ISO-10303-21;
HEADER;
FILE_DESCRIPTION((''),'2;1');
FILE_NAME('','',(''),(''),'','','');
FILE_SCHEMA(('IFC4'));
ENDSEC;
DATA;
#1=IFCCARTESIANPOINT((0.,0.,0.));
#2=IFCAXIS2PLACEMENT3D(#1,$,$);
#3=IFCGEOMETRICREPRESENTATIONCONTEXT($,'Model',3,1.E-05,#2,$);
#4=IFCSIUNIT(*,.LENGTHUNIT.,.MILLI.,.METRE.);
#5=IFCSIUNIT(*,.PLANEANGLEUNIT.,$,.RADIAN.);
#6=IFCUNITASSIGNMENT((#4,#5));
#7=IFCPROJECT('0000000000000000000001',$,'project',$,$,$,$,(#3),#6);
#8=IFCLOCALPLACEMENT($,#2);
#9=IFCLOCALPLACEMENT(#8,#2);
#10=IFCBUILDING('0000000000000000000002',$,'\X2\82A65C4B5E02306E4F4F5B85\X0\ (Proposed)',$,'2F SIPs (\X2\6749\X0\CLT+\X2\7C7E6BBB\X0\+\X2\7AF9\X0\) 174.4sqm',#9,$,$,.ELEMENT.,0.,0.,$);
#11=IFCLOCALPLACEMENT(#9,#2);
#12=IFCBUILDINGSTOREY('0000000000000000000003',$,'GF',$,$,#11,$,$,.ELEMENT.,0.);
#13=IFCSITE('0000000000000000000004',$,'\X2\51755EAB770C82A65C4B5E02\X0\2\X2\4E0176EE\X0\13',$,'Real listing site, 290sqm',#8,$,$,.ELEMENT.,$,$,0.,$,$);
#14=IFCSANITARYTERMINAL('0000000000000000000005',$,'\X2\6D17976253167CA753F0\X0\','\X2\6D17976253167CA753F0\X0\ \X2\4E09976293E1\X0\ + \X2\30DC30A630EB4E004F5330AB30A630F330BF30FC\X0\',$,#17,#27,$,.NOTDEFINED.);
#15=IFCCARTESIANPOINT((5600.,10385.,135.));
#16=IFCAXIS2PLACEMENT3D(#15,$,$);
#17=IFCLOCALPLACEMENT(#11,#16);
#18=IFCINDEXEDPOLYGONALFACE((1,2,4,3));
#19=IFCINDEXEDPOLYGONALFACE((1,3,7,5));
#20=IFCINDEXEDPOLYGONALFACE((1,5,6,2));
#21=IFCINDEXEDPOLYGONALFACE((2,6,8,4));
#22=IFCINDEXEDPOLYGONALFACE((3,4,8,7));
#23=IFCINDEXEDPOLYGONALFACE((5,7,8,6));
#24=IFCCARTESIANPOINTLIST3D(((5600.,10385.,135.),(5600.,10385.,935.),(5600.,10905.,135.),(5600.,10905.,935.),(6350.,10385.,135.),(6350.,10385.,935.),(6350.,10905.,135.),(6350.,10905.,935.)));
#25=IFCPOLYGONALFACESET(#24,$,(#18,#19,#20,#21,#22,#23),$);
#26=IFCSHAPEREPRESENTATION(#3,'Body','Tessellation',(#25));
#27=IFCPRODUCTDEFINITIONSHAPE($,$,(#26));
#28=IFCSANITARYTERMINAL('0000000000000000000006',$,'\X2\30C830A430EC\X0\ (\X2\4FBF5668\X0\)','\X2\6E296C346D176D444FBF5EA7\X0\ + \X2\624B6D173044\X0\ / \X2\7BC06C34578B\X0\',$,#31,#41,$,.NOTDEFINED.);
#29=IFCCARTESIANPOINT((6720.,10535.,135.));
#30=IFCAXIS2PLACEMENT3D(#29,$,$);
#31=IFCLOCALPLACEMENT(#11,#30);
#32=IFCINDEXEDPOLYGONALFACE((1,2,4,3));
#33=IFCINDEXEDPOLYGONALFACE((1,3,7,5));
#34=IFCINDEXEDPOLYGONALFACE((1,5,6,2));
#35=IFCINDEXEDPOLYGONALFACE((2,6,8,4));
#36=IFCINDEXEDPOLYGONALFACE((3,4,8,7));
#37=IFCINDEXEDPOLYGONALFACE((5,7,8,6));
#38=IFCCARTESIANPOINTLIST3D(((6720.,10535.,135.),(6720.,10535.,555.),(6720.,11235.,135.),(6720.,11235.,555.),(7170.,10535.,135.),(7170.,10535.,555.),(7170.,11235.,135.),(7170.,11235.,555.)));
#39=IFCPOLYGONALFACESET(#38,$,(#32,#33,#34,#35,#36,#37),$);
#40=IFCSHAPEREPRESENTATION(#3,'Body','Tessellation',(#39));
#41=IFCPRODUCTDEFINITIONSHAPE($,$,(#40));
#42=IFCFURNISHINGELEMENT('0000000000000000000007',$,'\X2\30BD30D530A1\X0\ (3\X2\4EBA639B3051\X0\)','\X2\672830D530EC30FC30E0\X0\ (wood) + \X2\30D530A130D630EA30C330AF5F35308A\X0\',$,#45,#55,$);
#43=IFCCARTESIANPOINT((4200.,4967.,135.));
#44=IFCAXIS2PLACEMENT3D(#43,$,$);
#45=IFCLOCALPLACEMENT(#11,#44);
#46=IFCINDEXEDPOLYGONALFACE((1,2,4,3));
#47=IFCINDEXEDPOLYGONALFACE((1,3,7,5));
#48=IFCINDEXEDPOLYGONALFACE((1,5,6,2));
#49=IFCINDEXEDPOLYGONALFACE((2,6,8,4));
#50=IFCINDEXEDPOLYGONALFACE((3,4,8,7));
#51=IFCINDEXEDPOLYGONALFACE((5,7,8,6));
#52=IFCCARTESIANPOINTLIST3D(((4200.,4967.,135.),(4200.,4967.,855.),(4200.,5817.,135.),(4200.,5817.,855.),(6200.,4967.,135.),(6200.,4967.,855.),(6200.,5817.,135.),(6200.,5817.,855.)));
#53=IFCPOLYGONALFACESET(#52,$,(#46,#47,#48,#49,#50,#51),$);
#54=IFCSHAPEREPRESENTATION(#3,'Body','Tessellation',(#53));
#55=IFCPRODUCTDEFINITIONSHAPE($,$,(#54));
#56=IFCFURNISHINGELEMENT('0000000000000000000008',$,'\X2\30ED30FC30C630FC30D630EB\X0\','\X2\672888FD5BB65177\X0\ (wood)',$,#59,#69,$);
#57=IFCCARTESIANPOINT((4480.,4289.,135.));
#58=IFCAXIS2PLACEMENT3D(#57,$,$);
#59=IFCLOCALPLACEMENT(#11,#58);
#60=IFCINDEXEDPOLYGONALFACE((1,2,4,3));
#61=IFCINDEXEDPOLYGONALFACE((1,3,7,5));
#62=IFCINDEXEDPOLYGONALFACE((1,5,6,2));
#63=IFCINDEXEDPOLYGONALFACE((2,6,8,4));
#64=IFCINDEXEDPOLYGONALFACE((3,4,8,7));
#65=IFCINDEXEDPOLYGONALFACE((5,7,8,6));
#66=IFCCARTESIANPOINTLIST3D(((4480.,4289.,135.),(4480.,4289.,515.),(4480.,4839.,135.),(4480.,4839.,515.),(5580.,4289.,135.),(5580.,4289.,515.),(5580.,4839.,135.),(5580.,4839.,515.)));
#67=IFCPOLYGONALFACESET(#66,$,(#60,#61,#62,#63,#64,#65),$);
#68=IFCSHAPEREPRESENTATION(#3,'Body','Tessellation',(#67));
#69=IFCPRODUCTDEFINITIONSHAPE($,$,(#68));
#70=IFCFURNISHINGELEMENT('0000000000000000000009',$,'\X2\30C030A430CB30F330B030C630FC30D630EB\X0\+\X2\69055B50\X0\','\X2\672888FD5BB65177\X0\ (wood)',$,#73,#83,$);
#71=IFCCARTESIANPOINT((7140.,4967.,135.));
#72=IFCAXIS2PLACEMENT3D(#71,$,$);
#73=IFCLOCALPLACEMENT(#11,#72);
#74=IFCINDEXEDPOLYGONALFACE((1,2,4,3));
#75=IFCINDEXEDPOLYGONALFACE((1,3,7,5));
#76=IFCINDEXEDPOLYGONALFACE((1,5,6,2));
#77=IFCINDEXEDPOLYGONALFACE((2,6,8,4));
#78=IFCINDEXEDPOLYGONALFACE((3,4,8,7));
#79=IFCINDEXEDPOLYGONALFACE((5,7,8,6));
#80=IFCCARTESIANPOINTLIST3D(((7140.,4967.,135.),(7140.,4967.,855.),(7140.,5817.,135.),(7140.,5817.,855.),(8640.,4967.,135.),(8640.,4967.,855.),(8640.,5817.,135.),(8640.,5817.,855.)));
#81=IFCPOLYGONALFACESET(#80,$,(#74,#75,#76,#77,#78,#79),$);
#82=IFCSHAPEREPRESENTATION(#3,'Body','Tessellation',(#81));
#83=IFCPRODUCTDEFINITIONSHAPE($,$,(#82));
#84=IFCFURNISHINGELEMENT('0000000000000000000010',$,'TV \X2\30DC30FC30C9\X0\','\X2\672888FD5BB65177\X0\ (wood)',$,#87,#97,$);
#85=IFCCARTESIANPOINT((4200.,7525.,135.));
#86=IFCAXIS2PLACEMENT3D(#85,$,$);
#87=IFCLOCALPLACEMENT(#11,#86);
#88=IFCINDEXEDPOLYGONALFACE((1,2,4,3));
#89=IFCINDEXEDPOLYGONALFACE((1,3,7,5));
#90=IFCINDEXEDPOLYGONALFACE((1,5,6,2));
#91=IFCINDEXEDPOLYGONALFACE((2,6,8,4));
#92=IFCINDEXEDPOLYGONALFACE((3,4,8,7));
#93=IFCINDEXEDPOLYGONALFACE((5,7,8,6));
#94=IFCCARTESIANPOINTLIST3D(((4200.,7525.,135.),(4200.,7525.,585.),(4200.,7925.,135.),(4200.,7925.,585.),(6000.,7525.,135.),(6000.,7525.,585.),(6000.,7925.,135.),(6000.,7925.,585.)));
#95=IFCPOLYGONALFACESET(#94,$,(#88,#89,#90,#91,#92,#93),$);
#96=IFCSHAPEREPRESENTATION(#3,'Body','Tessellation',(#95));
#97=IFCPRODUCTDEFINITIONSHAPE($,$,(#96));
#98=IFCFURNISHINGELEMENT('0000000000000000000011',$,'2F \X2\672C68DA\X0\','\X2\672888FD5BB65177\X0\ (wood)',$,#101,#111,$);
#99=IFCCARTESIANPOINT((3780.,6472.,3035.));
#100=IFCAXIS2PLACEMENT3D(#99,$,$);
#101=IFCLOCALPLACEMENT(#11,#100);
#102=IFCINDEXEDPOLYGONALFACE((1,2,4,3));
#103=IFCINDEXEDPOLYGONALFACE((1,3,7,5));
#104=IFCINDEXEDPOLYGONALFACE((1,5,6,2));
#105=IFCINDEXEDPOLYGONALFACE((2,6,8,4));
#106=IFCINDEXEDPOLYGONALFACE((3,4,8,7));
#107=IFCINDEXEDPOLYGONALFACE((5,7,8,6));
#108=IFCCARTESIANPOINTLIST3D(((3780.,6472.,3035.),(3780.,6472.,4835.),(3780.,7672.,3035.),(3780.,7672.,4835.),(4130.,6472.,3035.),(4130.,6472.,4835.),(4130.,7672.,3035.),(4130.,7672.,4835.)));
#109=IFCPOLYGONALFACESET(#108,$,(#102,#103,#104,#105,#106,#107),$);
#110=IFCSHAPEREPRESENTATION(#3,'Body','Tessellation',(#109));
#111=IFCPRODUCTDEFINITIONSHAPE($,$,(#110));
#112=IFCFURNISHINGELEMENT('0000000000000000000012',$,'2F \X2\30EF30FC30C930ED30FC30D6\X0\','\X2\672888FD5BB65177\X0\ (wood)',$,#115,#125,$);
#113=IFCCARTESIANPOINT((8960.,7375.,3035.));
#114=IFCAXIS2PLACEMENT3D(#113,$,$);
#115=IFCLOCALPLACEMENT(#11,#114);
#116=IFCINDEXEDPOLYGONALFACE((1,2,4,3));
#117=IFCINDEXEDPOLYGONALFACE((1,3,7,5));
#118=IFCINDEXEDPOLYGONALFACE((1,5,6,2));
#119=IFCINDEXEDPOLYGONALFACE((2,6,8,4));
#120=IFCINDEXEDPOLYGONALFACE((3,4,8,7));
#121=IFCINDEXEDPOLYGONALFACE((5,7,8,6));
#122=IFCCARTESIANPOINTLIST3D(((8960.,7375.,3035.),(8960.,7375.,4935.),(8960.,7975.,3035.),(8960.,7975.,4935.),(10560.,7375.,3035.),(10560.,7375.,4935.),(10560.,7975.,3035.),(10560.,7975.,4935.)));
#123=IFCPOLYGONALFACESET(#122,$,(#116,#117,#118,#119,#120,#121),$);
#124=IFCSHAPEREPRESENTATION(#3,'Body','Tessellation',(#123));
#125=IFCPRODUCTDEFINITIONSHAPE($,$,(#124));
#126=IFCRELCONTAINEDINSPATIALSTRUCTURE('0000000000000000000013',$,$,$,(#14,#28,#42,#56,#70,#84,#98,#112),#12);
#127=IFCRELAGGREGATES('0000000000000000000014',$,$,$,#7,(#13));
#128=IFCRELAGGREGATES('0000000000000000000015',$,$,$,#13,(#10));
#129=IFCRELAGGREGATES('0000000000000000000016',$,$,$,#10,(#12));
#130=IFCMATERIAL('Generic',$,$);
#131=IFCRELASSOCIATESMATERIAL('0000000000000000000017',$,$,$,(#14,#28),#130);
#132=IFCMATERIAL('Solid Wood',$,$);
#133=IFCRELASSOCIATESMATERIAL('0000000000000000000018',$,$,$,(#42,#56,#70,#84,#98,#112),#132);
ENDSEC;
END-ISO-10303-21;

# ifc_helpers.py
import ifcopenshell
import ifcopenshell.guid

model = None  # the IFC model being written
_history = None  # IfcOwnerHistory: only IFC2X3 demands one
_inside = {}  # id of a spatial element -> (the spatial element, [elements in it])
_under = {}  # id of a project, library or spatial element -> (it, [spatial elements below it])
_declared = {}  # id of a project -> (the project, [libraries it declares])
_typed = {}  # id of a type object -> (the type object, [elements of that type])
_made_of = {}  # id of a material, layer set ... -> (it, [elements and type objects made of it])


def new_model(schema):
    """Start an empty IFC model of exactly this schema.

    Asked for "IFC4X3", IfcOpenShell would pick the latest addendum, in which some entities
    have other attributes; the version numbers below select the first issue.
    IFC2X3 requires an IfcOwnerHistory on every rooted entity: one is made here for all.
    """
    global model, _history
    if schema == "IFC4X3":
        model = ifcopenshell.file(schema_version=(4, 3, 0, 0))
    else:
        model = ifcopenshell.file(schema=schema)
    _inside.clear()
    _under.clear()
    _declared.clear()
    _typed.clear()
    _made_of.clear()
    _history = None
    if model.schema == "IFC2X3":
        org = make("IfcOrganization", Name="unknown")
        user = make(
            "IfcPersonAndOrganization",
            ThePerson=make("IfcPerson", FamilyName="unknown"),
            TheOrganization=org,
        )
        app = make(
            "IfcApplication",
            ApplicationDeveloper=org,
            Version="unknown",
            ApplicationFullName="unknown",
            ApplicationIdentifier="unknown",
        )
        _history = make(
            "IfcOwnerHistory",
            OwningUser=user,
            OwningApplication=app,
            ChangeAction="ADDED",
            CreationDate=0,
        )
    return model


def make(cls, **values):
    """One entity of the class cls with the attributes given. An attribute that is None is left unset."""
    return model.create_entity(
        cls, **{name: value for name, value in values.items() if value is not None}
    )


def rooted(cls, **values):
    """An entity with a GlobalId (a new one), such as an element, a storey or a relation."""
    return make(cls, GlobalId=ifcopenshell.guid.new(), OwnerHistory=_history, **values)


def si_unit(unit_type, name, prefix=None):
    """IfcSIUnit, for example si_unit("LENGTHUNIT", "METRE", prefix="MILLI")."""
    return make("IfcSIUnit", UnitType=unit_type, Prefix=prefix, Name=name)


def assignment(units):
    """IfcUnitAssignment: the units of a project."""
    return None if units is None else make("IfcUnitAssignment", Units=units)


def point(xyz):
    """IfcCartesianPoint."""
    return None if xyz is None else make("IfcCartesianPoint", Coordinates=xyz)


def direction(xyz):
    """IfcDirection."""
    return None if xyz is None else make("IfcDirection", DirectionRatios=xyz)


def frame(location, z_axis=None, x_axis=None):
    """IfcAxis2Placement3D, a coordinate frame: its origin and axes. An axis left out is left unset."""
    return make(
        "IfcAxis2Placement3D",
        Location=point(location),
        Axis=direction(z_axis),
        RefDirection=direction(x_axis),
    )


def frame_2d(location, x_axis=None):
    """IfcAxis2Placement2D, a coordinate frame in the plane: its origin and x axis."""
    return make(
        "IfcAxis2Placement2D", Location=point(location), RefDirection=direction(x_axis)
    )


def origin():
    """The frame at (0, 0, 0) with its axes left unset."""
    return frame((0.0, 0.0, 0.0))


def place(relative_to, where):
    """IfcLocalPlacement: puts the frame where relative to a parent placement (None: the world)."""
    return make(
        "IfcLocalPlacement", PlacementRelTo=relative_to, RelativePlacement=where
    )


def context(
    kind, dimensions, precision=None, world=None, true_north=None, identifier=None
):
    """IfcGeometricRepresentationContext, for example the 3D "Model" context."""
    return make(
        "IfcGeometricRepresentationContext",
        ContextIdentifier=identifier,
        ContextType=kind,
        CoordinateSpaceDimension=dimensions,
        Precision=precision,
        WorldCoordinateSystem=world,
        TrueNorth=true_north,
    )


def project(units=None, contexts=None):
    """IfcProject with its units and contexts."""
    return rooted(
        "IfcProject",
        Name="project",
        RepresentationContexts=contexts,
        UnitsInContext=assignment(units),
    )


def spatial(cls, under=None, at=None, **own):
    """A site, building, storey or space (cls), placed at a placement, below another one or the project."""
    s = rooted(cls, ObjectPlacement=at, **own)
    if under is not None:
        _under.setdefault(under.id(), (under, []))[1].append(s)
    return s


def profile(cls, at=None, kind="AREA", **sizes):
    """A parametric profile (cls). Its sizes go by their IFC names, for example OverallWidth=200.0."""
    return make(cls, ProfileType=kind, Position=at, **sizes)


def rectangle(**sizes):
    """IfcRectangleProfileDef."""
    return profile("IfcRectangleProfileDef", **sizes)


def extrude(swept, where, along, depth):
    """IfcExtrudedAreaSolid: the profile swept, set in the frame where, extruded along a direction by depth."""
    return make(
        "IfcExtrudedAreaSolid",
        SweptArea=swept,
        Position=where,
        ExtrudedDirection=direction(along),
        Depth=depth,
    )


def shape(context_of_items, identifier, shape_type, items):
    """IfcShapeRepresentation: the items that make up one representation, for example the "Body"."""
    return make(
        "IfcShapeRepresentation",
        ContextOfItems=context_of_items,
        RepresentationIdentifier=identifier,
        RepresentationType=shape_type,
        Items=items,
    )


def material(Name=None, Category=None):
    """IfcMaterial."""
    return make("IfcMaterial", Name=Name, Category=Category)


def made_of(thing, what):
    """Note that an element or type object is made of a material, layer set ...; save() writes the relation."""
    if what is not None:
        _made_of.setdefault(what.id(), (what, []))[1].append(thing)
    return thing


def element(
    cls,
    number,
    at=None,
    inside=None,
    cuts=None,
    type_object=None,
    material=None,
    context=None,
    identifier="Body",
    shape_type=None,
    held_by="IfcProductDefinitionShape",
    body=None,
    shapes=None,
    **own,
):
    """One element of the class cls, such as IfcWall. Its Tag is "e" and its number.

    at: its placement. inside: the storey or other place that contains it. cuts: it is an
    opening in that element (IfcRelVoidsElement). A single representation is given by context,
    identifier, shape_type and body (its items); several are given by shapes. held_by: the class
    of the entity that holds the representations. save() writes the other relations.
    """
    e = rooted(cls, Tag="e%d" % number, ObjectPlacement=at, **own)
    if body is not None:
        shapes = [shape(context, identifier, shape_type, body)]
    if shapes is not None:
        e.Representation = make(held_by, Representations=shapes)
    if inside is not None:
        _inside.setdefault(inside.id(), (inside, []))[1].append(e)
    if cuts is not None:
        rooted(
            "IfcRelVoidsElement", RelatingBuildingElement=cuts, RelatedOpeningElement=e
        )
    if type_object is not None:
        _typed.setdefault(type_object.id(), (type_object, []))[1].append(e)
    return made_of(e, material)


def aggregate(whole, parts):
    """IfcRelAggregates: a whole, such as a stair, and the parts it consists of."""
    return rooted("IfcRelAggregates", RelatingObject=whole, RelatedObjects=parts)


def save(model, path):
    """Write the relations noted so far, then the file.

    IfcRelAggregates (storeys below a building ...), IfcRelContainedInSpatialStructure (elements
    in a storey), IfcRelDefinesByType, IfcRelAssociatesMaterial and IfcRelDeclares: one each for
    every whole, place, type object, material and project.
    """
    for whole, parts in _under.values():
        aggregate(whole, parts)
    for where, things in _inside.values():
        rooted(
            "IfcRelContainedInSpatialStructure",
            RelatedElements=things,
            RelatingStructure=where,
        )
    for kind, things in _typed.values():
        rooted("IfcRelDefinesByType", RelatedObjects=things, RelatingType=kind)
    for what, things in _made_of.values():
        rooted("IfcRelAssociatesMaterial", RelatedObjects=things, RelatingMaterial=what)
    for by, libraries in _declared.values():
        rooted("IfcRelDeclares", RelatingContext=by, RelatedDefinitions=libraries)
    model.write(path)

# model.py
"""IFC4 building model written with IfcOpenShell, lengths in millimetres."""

from ifc_helpers import new_model, si_unit, frame, frame_2d, origin, place, context, project, spatial, rectangle, extrude, material, element, save


model = new_model("IFC4")

# Units and contexts
model_context = context("Model", 3, precision=1e-05, world=origin())
ifc_project = project(units=[si_unit("LENGTHUNIT", "METRE", prefix="MILLI"), si_unit("PLANEANGLEUNIT", "RADIAN")], contexts=[model_context])

# Site, building, storey
site_placement = place(None, origin())
site = spatial("IfcSite", under=ifc_project, at=site_placement, Name="兵庫県芦屋市2丁目13", ObjectType="Real listing site, 290sqm", CompositionType="ELEMENT", RefElevation=0.0)
building_placement = place(site_placement, origin())
building = spatial("IfcBuilding", under=site, at=building_placement, Name="芦屋市の住宅 (Proposed)", ObjectType="2F SIPs (杉CLT+籾殻+竹) 174.4sqm", CompositionType="ELEMENT", ElevationOfRefHeight=0.0, ElevationOfTerrain=0.0)
storey_placement = place(building_placement, origin())
storey = spatial("IfcBuildingStorey", under=building, at=storey_placement, Name="GF", CompositionType="ELEMENT", Elevation=0.0)

# Shared definitions
ifc_material_1 = material(Name="Generic")

# Shared definitions
ifc_material_2 = material(Name="Solid Wood")

# Sanitary terminals
sanitary_terminal_1_placement = place(storey_placement, frame((5600.0, 10385.0, 135.0)))
element("IfcSanitaryTerminal", 1, at=sanitary_terminal_1_placement, inside=storey, material=ifc_material_1, Name="洗面化粧台", Description="洗面化粧台 三面鏡 + ボウル一体カウンター", PredefinedType="NOTDEFINED", context=model_context, shape_type="SweptSolid", body=[
    extrude(rectangle(XDim=750.0, YDim=520.0, at=frame_2d((375.0, 260.0))), frame((5600.0, 10385.0, 135.0)), (0.0, 0.0, 1.0), 800.0),
])
sanitary_terminal_2_placement = place(storey_placement, frame((6720.0, 10535.0, 135.0)))
element("IfcSanitaryTerminal", 2, at=sanitary_terminal_2_placement, inside=storey, material=ifc_material_1, Name="トイレ (便器)", Description="温水洗浄便座 + 手洗い / 節水型", PredefinedType="NOTDEFINED", context=model_context, shape_type="SweptSolid", body=[
    extrude(rectangle(XDim=450.0, YDim=700.0, at=frame_2d((225.0, 350.0))), frame((6720.0, 10535.0, 135.0)), (0.0, 0.0, 1.0), 420.0),
])

# Furnishing elements
furnishing_1_placement = place(storey_placement, frame((4200.0, 4967.0, 135.0)))
element("IfcFurnishingElement", 3, at=furnishing_1_placement, inside=storey, material=ifc_material_2, Name="ソファ (3人掛け)", Description="木フレーム (wood) + ファブリック張り", context=model_context, shape_type="SweptSolid", body=[
    extrude(rectangle(XDim=2000.0, YDim=850.0, at=frame_2d((1000.0, 425.0))), frame((4200.0, 4967.0, 135.0)), (0.0, 0.0, 1.0), 720.0),
])
furnishing_2_placement = place(storey_placement, frame((4480.0, 4289.0, 135.0)))
element("IfcFurnishingElement", 4, at=furnishing_2_placement, inside=storey, material=ifc_material_2, Name="ローテーブル", Description="木製家具 (wood)", context=model_context, shape_type="SweptSolid", body=[
    extrude(rectangle(XDim=1100.0, YDim=550.0, at=frame_2d((550.0, 275.0))), frame((4480.0, 4289.0, 135.0)), (0.0, 0.0, 1.0), 380.0),
])
furnishing_3_placement = place(storey_placement, frame((7140.0, 4967.0, 135.0)))
element("IfcFurnishingElement", 5, at=furnishing_3_placement, inside=storey, material=ifc_material_2, Name="ダイニングテーブル+椅子", Description="木製家具 (wood)", context=model_context, shape_type="SweptSolid", body=[
    extrude(rectangle(XDim=1500.0, YDim=850.0, at=frame_2d((750.0, 425.0))), frame((7140.0, 4967.0, 135.0)), (0.0, 0.0, 1.0), 720.0),
])
furnishing_4_placement = place(storey_placement, frame((4200.0, 7525.0, 135.0)))
element("IfcFurnishingElement", 6, at=furnishing_4_placement, inside=storey, material=ifc_material_2, Name="TV ボード", Description="木製家具 (wood)", context=model_context, shape_type="SweptSolid", body=[
    extrude(rectangle(XDim=1800.0, YDim=400.0, at=frame_2d((900.0, 200.0))), frame((4200.0, 7525.0, 135.0)), (0.0, 0.0, 1.0), 450.0),
])
furnishing_5_placement = place(storey_placement, frame((3780.0, 6472.0, 3035.0)))
element("IfcFurnishingElement", 7, at=furnishing_5_placement, inside=storey, material=ifc_material_2, Name="2F 本棚", Description="木製家具 (wood)", context=model_context, shape_type="SweptSolid", body=[
    extrude(rectangle(XDim=350.0, YDim=1200.0, at=frame_2d((175.0, 600.0))), frame((3780.0, 6472.0, 3035.0)), (0.0, 0.0, 1.0), 1800.0),
])
furnishing_6_placement = place(storey_placement, frame((8960.0, 7375.0, 3035.0)))
element("IfcFurnishingElement", 8, at=furnishing_6_placement, inside=storey, material=ifc_material_2, Name="2F ワードローブ", Description="木製家具 (wood)", context=model_context, shape_type="SweptSolid", body=[
    extrude(rectangle(XDim=1600.0, YDim=600.0, at=frame_2d((800.0, 300.0))), frame((8960.0, 7375.0, 3035.0)), (0.0, 0.0, 1.0), 1900.0),
])

save(model, "model.ifc")
